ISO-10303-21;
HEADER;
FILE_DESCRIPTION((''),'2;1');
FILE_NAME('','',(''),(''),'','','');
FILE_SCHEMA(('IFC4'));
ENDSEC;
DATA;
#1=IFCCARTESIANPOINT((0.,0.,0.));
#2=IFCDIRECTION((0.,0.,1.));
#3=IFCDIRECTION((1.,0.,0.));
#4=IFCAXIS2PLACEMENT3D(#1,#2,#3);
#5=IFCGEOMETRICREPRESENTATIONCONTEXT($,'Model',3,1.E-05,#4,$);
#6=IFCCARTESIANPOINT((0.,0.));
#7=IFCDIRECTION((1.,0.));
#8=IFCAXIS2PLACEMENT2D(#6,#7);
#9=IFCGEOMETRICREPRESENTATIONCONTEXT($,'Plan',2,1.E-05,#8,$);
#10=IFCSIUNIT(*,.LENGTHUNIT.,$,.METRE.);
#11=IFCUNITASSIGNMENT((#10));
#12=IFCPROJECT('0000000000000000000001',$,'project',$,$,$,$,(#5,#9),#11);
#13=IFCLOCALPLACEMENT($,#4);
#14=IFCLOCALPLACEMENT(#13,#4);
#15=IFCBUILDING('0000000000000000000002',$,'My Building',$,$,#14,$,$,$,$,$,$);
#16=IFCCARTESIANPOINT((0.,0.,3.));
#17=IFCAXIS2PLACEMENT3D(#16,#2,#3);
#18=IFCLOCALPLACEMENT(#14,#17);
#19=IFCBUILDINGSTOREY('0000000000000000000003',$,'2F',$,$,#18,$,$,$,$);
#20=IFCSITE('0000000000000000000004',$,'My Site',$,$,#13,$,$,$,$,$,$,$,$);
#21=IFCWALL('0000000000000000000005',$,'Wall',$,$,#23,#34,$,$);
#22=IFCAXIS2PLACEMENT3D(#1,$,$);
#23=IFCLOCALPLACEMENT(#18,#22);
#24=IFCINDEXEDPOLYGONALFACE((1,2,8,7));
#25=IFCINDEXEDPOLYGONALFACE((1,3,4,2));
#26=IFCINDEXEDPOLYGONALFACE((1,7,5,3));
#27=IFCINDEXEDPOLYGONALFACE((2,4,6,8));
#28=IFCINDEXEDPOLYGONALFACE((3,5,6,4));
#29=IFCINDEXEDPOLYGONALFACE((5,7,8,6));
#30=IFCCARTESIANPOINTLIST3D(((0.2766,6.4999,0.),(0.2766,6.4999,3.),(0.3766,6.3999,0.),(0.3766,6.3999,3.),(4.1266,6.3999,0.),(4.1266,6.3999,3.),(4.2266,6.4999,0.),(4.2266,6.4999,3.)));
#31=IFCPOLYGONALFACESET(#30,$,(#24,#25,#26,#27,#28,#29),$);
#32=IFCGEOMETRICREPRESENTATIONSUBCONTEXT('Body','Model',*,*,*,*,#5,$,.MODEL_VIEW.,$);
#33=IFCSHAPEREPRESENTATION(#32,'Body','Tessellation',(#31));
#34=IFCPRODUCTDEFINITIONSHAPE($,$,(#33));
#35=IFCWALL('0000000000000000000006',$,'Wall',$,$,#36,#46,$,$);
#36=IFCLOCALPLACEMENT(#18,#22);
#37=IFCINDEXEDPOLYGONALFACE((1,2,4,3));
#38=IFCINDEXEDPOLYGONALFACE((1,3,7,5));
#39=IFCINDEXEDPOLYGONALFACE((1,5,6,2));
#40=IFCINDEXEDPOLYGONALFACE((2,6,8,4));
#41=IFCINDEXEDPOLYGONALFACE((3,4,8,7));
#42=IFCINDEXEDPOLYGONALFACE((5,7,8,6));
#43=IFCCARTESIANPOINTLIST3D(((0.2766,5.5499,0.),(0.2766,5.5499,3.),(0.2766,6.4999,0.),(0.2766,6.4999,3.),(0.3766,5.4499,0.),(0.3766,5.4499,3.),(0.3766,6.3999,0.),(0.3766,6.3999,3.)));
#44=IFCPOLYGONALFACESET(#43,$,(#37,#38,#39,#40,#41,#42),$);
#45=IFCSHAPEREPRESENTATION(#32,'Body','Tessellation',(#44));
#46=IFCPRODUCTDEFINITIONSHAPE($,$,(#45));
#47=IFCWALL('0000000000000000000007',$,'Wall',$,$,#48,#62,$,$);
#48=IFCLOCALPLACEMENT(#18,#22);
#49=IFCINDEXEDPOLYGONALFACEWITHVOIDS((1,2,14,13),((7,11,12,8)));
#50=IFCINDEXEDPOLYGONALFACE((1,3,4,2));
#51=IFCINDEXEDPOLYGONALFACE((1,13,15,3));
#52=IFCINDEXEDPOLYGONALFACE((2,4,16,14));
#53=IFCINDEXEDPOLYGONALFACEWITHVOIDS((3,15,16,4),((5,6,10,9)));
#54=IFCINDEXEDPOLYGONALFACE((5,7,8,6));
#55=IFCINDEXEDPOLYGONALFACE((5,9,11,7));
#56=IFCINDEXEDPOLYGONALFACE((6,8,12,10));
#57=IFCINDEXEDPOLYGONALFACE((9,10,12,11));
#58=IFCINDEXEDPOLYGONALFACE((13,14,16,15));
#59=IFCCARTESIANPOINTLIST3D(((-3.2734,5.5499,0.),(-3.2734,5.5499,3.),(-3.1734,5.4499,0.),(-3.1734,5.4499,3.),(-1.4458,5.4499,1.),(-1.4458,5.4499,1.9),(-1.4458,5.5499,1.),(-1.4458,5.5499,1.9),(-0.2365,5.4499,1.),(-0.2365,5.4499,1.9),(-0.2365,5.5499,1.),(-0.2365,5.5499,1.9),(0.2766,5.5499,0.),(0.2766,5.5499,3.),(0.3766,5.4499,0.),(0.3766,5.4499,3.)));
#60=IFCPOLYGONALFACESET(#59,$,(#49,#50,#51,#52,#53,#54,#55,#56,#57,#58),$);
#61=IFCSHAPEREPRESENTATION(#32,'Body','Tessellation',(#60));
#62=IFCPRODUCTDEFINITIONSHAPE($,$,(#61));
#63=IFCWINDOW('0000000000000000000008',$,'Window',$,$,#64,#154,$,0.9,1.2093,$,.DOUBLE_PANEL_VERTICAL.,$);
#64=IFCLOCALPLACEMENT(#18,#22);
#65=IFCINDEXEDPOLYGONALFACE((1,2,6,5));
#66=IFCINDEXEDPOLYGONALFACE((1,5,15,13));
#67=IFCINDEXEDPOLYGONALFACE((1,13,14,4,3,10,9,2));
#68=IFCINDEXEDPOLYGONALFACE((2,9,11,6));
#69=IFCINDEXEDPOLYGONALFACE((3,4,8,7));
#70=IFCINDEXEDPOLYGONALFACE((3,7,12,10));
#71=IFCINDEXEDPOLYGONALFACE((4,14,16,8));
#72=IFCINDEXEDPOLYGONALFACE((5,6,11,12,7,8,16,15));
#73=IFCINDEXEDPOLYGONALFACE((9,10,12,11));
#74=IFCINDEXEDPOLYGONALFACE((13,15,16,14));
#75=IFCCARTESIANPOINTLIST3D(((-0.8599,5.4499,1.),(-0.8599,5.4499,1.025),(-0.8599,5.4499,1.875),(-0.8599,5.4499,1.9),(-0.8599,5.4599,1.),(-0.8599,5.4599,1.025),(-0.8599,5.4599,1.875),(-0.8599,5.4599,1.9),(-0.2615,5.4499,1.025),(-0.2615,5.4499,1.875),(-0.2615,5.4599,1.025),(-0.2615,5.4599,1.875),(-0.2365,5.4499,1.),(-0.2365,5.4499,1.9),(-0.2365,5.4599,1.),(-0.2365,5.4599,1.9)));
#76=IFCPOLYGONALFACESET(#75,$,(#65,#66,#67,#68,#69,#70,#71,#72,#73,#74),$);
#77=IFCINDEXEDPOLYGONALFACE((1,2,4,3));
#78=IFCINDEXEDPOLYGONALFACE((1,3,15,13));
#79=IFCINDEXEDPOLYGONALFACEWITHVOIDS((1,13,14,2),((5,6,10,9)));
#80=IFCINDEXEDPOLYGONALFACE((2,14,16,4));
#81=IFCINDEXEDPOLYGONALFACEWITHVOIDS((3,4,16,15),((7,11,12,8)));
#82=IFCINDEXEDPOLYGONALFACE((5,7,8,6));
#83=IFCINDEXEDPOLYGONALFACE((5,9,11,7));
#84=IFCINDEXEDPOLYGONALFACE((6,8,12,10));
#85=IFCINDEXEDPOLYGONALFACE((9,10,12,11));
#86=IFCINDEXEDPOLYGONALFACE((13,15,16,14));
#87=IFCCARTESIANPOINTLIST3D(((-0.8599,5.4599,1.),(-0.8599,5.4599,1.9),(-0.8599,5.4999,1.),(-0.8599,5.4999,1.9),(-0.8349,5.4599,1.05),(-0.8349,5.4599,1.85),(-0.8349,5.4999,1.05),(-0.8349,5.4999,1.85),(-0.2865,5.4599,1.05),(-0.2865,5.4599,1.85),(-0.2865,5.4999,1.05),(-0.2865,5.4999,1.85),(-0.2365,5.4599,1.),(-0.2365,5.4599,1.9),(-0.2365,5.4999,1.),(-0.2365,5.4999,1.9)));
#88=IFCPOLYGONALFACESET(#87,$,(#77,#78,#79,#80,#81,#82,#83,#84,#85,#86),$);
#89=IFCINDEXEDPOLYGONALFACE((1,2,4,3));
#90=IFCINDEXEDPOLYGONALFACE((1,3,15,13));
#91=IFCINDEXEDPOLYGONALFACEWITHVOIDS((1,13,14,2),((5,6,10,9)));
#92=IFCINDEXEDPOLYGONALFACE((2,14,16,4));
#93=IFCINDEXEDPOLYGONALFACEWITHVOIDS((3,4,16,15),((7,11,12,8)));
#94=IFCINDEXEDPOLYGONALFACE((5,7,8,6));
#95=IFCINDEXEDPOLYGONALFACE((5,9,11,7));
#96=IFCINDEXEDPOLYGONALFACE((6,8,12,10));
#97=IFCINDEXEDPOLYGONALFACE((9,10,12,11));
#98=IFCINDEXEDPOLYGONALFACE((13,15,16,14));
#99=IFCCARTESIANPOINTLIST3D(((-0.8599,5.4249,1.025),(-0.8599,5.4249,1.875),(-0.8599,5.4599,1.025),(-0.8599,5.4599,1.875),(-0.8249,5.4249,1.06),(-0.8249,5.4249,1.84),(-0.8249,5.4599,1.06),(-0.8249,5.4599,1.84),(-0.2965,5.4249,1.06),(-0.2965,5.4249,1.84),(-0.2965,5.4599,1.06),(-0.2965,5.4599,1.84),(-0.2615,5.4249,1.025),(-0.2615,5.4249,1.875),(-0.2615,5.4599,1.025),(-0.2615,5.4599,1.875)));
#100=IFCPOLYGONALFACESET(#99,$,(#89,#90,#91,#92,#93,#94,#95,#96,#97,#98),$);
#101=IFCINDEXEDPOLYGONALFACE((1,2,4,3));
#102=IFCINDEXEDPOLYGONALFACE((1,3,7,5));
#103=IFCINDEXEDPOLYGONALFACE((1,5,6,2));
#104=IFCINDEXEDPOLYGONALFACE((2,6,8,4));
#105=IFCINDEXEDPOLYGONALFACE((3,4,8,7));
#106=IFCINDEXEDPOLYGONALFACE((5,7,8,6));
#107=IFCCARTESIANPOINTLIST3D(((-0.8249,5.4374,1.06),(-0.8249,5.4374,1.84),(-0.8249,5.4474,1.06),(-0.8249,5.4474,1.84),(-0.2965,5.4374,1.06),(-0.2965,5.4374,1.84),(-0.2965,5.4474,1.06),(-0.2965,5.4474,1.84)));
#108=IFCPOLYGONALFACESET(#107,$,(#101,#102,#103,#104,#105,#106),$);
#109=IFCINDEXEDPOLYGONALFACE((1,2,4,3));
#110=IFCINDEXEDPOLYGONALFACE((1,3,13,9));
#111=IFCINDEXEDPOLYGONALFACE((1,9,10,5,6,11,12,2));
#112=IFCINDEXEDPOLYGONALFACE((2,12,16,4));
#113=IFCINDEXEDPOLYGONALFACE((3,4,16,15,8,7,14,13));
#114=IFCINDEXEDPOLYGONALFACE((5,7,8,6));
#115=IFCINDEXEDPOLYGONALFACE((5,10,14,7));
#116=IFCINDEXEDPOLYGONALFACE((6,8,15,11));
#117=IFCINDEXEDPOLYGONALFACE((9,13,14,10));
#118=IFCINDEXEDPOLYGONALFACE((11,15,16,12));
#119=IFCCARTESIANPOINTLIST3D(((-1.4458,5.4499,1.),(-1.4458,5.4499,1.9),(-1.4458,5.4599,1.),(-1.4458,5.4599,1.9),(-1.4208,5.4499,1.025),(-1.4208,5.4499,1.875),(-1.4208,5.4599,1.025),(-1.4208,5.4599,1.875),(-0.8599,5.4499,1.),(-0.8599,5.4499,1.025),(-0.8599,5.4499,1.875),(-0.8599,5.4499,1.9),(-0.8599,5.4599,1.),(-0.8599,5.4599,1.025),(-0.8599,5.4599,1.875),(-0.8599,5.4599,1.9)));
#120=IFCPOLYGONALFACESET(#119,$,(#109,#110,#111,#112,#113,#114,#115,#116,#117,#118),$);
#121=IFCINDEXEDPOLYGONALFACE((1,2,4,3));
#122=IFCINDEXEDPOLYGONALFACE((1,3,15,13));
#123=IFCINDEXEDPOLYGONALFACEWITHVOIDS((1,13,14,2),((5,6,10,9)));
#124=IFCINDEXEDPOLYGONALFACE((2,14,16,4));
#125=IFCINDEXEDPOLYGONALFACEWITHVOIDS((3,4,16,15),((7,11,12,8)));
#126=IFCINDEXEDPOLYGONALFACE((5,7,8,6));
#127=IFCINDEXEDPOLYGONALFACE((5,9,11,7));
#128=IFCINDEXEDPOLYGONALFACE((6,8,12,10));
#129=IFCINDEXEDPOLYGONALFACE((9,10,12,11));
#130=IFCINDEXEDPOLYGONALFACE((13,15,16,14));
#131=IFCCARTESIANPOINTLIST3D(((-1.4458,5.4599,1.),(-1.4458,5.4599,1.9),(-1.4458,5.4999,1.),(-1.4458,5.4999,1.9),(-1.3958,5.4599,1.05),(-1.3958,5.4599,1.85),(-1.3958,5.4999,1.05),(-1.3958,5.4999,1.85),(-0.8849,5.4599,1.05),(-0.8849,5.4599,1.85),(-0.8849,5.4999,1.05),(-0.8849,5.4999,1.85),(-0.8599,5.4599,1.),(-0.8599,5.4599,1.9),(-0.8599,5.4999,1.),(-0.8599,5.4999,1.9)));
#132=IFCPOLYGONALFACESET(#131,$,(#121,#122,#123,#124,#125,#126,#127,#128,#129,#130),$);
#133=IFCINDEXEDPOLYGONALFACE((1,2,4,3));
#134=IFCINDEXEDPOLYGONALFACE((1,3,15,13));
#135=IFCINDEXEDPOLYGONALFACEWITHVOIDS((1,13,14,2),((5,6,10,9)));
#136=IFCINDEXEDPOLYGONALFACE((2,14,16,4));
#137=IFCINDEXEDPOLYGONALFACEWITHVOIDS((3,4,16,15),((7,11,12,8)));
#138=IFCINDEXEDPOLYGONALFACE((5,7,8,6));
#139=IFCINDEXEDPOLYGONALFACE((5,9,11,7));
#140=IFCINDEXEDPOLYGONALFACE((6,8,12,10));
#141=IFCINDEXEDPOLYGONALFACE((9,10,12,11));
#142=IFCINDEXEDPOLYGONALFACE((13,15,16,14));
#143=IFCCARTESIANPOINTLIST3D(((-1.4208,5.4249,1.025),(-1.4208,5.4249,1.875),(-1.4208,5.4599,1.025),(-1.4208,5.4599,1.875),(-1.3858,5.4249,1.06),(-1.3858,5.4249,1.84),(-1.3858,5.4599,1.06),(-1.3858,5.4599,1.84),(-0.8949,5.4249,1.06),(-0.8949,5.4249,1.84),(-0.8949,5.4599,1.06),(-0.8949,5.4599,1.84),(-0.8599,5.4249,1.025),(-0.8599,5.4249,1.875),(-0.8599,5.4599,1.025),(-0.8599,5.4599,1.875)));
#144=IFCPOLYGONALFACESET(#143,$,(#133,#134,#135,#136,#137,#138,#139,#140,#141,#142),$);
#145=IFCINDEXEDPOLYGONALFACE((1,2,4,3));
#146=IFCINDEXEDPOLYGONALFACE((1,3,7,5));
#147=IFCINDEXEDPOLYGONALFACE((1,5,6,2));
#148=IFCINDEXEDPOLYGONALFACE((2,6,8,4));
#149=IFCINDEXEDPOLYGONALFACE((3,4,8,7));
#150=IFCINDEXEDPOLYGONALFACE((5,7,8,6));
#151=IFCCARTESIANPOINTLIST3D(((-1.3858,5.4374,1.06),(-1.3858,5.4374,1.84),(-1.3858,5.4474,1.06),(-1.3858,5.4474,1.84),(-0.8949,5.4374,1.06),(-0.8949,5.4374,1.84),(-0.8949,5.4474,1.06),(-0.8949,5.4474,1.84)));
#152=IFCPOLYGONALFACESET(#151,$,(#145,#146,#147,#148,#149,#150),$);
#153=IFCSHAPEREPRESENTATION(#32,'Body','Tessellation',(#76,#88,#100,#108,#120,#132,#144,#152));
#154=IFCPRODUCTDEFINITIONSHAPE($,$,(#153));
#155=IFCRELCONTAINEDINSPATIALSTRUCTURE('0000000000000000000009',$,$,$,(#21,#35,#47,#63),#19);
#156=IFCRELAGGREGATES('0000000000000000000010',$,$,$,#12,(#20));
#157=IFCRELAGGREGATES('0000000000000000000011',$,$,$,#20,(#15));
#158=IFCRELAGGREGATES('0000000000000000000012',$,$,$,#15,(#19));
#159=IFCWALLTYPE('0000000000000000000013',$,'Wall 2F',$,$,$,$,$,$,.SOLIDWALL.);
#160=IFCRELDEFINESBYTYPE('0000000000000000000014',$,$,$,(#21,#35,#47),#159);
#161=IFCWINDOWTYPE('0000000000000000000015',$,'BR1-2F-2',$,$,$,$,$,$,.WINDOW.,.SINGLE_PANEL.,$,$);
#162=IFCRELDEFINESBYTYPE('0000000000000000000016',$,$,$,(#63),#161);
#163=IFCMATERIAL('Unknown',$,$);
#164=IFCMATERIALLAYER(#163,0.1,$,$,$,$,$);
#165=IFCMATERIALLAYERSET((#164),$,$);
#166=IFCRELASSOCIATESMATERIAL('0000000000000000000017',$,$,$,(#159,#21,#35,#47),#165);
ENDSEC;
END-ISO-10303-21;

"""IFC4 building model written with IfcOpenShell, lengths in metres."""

from ifc_helpers import new_model, entity, si_unit, frame, origin_with_axes, origin_2d_with_axis, place, context, subcontext, project, spatial, line, indexed_curve, outline, extrude, shape, source, transform, mapped, material, layer, layer_set, layer_usage, type_object, type_shapes, element, fill, save


model = new_model("IFC4")

# Units and contexts
model_context = context("Model", 3, precision=1e-05, world=origin_with_axes())
plan_context = context("Plan", 2, precision=1e-05, world=origin_2d_with_axis())
body_context_1 = subcontext(model_context, "Body", "Model", "MODEL_VIEW")
body_context_2 = subcontext(plan_context, "Body", "Plan", "PLAN_VIEW")
ifc_project = project(units=[si_unit("LENGTHUNIT", "METRE")], contexts=[model_context, plan_context])

# Site, building, storey
site_placement = place(None, origin_with_axes())
site = spatial("IfcSite", under=ifc_project, at=site_placement, Name="My Site")
building_placement = place(site_placement, origin_with_axes())
building = spatial("IfcBuilding", under=site, at=building_placement, Name="My Building")
storey_placement = place(building_placement, frame((0.0, 0.0, 3.0), z_axis=(0.0, 0.0, 1.0), x_axis=(1.0, 0.0, 0.0)))
storey = spatial("IfcBuildingStorey", under=building, at=storey_placement, Name="2F")

# Walls
ifc_material = material(Name="Unknown")
ifc_layer_1 = layer(ifc_material, 0.1)
ifc_layer_set_1 = layer_set([ifc_layer_1])
ifc_layer_usage_1 = layer_usage(ifc_layer_set_1, "AXIS2", "POSITIVE", 0.0)
wall_type_1 = type_object("IfcWallType", Name="Wall 2F", PredefinedType="SOLIDWALL", material=ifc_layer_set_1)
wall_1_placement = place(storey_placement, frame((4.2266, 6.4999, 0.0), z_axis=(0.0, 0.0, 1.0), x_axis=(-1.0, 0.0, 0.0)))
element("IfcWall", 1, at=wall_1_placement, inside=storey, type_object=wall_type_1, material=ifc_layer_usage_1, Name="Wall", context=body_context_1, shape_type="SweptSolid", body=[
    extrude(outline(indexed_curve([(0.0, 0.0), (0.1, 0.1), (3.85, 0.1), (3.95, 0.0)], segments=[line(1, 2, 3, 4, 1)])), origin_with_axes(), (0.0, 0.0, 1.0), 3.0),
])
ifc_layer_usage_2 = layer_usage(ifc_layer_set_1, "AXIS2", "POSITIVE", 0.0)
wall_2_placement = place(storey_placement, frame((0.2766, 6.4999, 0.0), z_axis=(0.0, 0.0, 1.0), x_axis=(0.0, -1.0, 0.0)))
element("IfcWall", 2, at=wall_2_placement, inside=storey, type_object=wall_type_1, material=ifc_layer_usage_2, Name="Wall", context=body_context_1, shape_type="SweptSolid", body=[
    extrude(outline(indexed_curve([(0.0, 0.0), (0.1, 0.1), (1.05, 0.1), (0.95, 0.0)], segments=[line(1, 2, 3, 4, 1)])), origin_with_axes(), (0.0, 0.0, 1.0), 3.0),
])

# Wall, opening, window
ifc_layer_usage_3 = layer_usage(ifc_layer_set_1, "AXIS2", "POSITIVE", 0.0)
wall_3_placement = place(storey_placement, frame((0.2766, 5.5499, 0.0), z_axis=(0.0, 0.0, 1.0), x_axis=(-1.0, 0.0, 0.0)))
wall_3 = element("IfcWall", 3, at=wall_3_placement, inside=storey, type_object=wall_type_1, material=ifc_layer_usage_3, Name="Wall", context=body_context_1, shape_type="SweptSolid", body=[
    extrude(outline(indexed_curve([(0.0, 0.0), (-0.1, 0.1), (3.45, 0.1), (3.55, 0.0)], segments=[line(1, 2, 3, 4, 1)])), origin_with_axes(), (0.0, 0.0, 1.0), 3.0),
])
shared_shape_1 = source(origin_with_axes(), body_context_1, "Body", "SweptSolid", [
    extrude(outline(indexed_curve([(0.0, 0.0), (1.2093, 0.0), (1.2093, 0.9), (0.0, 0.9)], segments=[line(1, 2, 3, 4, 1)])), frame((0.0, -0.6, 0.0), z_axis=(0.0, -1.0, 0.0), x_axis=(1.0, 0.0, 0.0)), (0.0, 0.0, -1.0), 1.2),
])
opening_1_placement = place(wall_3_placement, frame((0.5131, 0.0, 1.0), z_axis=(0.0, 0.0, 1.0), x_axis=(1.0, 0.0, 0.0)))
opening_1 = element("IfcOpeningElement", 4, at=opening_1_placement, cuts=wall_3, PredefinedType="OPENING", context=body_context_1, shape_type="MappedRepresentation", body=[
    mapped(shared_shape_1, transform((0.0, 0.0, 0.0), x_axis=(1.0, 0.0, 0.0), y_axis=(0.0, 1.0, 0.0), z_axis=(0.0, 0.0, 1.0), scale=1.0)),
])
window_type_1 = type_object("IfcWindowType", Name="BR1-2F-2", PartitioningType="SINGLE_PANEL", PredefinedType="WINDOW")
shared_shape_2 = source(origin_with_axes(), body_context_1, "Body", "SweptSolid", [
    extrude(outline(indexed_curve([(0.6234, 0.0), (0.0, 0.0), (0.0, 0.9), (0.6234, 0.9), (0.6234, 0.875), (0.025, 0.875), (0.025, 0.025), (0.6234, 0.025)], segments=[line(1, 2, 3, 4, 5, 6, 7, 8, 1)])), frame((0.0, 0.09, 0.0), z_axis=(0.0, -1.0, 0.0), x_axis=(1.0, 0.0, 0.0)), (0.0, 0.0, -1.0), 0.01),
    extrude(outline(indexed_curve([(0.0, 0.0), (0.6234, 0.0), (0.6234, 0.9), (0.0, 0.9)], segments=[line(1, 2, 3, 4, 1)]), holes=[indexed_curve([(0.05, 0.05), (0.5984, 0.05), (0.5984, 0.85), (0.05, 0.85)], segments=[line(1, 2, 3, 4, 1)])]), frame((0.0, 0.05, 0.0), z_axis=(0.0, -1.0, 0.0), x_axis=(1.0, 0.0, 0.0)), (0.0, 0.0, -1.0), 0.04),
    extrude(outline(indexed_curve([(0.0, 0.0), (0.5984, 0.0), (0.5984, 0.85), (0.0, 0.85)], segments=[line(1, 2, 3, 4, 1)]), holes=[indexed_curve([(0.035, 0.035), (0.5634, 0.035), (0.5634, 0.815), (0.035, 0.815)], segments=[line(1, 2, 3, 4, 1)])]), frame((0.025, 0.09, 0.025), z_axis=(0.0, -1.0, 0.0), x_axis=(1.0, 0.0, 0.0)), (0.0, 0.0, -1.0), 0.035),
    extrude(outline(indexed_curve([(0.035, 0.035), (0.5634, 0.035), (0.5634, 0.815), (0.035, 0.815)], segments=[line(1, 2, 3, 4, 1)])), frame((0.025, 0.1025, 0.025), z_axis=(0.0, -1.0, 0.0), x_axis=(1.0, 0.0, 0.0)), (0.0, 0.0, -1.0), 0.01),
    extrude(outline(indexed_curve([(0.0, 0.9), (0.5859, 0.9), (0.5859, 0.0), (0.0, 0.0), (0.0, 0.025), (0.5609, 0.025), (0.5609, 0.875), (0.0, 0.875)], segments=[line(1, 2, 3, 4, 5, 6, 7, 8, 1)])), frame((0.6234, 0.09, 0.0), z_axis=(0.0, -1.0, 0.0), x_axis=(1.0, 0.0, 0.0)), (0.0, 0.0, -1.0), 0.01),
    extrude(outline(indexed_curve([(0.0, 0.0), (0.5859, 0.0), (0.5859, 0.9), (0.0, 0.9)], segments=[line(1, 2, 3, 4, 1)]), holes=[indexed_curve([(0.025, 0.05), (0.5359, 0.05), (0.5359, 0.85), (0.025, 0.85)], segments=[line(1, 2, 3, 4, 1)])]), frame((0.6234, 0.05, 0.0), z_axis=(0.0, -1.0, 0.0), x_axis=(1.0, 0.0, 0.0)), (0.0, 0.0, -1.0), 0.04),
    extrude(outline(indexed_curve([(0.0, 0.0), (0.5609, 0.0), (0.5609, 0.85), (0.0, 0.85)], segments=[line(1, 2, 3, 4, 1)]), holes=[indexed_curve([(0.035, 0.035), (0.5259, 0.035), (0.5259, 0.815), (0.035, 0.815)], segments=[line(1, 2, 3, 4, 1)])]), frame((0.6234, 0.09, 0.025), z_axis=(0.0, -1.0, 0.0), x_axis=(1.0, 0.0, 0.0)), (0.0, 0.0, -1.0), 0.035),
    extrude(outline(indexed_curve([(0.035, 0.035), (0.5259, 0.035), (0.5259, 0.815), (0.035, 0.815)], segments=[line(1, 2, 3, 4, 1)])), frame((0.6234, 0.1025, 0.025), z_axis=(0.0, -1.0, 0.0), x_axis=(1.0, 0.0, 0.0)), (0.0, 0.0, -1.0), 0.01),
])
shared_shape_3 = source(origin_with_axes(), body_context_2, "Body", "Curve2D", [
    entity("IfcIndexedPolyCurve", entity("IfcCartesianPointList2D", [[0.05, 0.05], [0.5984, 0.05]])),
    entity("IfcIndexedPolyCurve", entity("IfcCartesianPointList2D", [[0.0, 0.1], [0.025, 0.1], [0.025, 0.09], [0.05, 0.09], [0.05, 0.05], [0.0, 0.05]]), [entity("IfcLineIndex", [1, 2, 3, 4, 5, 6, 1])]),
    entity("IfcIndexedPolyCurve", entity("IfcCartesianPointList2D", [[0.6234, 0.1], [0.6234, 0.1], [0.6234, 0.09], [0.5984, 0.09], [0.5984, 0.05], [0.6234, 0.05]])),
    entity("IfcIndexedPolyCurve", entity("IfcCartesianPointList2D", [[0.025, 0.09], [0.06, 0.09], [0.06, 0.125], [0.025, 0.125]]), [entity("IfcLineIndex", [1, 2, 3, 4, 1])]),
    entity("IfcIndexedPolyCurve", entity("IfcCartesianPointList2D", [[0.6234, 0.09], [0.5884, 0.09], [0.5884, 0.125], [0.6234, 0.125]]), [entity("IfcLineIndex", [1, 2, 3, 4, 1])]),
    entity("IfcIndexedPolyCurve", entity("IfcCartesianPointList2D", [[0.06, 0.09], [0.5884, 0.09]])),
    entity("IfcIndexedPolyCurve", entity("IfcCartesianPointList2D", [[0.06, 0.125], [0.5884, 0.125]])),
    entity("IfcIndexedPolyCurve", entity("IfcCartesianPointList2D", [[0.06, 0.1075], [0.5884, 0.1075]])),
    entity("IfcIndexedPolyCurve", entity("IfcCartesianPointList2D", [[0.6484, 0.05], [1.1593, 0.05]])),
    entity("IfcIndexedPolyCurve", entity("IfcCartesianPointList2D", [[0.6234, 0.1], [0.6234, 0.1], [0.6234, 0.09], [0.6484, 0.09], [0.6484, 0.05], [0.6234, 0.05]])),
    entity("IfcIndexedPolyCurve", entity("IfcCartesianPointList2D", [[1.2093, 0.1], [1.1843, 0.1], [1.1843, 0.09], [1.1593, 0.09], [1.1593, 0.05], [1.2093, 0.05]]), [entity("IfcLineIndex", [1, 2, 3, 4, 5, 6, 1])]),
    entity("IfcIndexedPolyCurve", entity("IfcCartesianPointList2D", [[0.6234, 0.09], [0.6584, 0.09], [0.6584, 0.125], [0.6234, 0.125]]), [entity("IfcLineIndex", [1, 2, 3, 4, 1])]),
    entity("IfcIndexedPolyCurve", entity("IfcCartesianPointList2D", [[1.1843, 0.09], [1.1493, 0.09], [1.1493, 0.125], [1.1843, 0.125]]), [entity("IfcLineIndex", [1, 2, 3, 4, 1])]),
    entity("IfcIndexedPolyCurve", entity("IfcCartesianPointList2D", [[0.6584, 0.09], [1.1493, 0.09]])),
    entity("IfcIndexedPolyCurve", entity("IfcCartesianPointList2D", [[0.6584, 0.125], [1.1493, 0.125]])),
    entity("IfcIndexedPolyCurve", entity("IfcCartesianPointList2D", [[0.6584, 0.1075], [1.1493, 0.1075]])),
])
type_shapes(window_type_1, [shared_shape_2, shared_shape_3])
window_1_placement = place(opening_1_placement, frame((0.0, 0.0, 0.0), z_axis=(0.0, 0.0, 1.0), x_axis=(1.0, 0.0, 0.0)))
window_1 = element("IfcWindow", 5, at=window_1_placement, inside=storey, type_object=window_type_1, Name="Window", OverallHeight=0.9, OverallWidth=1.2093, PartitioningType="DOUBLE_PANEL_VERTICAL", shapes=[
    shape(body_context_1, "Body", "MappedRepresentation", [mapped(shared_shape_2, transform((0.0, 0.0, 0.0), x_axis=(1.0, 0.0, 0.0), y_axis=(0.0, 1.0, 0.0), z_axis=(0.0, 0.0, 1.0), scale=1.0))]),
    shape(body_context_2, "Body", "MappedRepresentation", [mapped(shared_shape_3, transform((0.0, 0.0, 0.0), x_axis=(1.0, 0.0, 0.0), y_axis=(0.0, 1.0, 0.0), z_axis=(0.0, 0.0, 1.0), scale=1.0))]),
])
fill(opening_1, window_1)

save(model, "model.ifc")
